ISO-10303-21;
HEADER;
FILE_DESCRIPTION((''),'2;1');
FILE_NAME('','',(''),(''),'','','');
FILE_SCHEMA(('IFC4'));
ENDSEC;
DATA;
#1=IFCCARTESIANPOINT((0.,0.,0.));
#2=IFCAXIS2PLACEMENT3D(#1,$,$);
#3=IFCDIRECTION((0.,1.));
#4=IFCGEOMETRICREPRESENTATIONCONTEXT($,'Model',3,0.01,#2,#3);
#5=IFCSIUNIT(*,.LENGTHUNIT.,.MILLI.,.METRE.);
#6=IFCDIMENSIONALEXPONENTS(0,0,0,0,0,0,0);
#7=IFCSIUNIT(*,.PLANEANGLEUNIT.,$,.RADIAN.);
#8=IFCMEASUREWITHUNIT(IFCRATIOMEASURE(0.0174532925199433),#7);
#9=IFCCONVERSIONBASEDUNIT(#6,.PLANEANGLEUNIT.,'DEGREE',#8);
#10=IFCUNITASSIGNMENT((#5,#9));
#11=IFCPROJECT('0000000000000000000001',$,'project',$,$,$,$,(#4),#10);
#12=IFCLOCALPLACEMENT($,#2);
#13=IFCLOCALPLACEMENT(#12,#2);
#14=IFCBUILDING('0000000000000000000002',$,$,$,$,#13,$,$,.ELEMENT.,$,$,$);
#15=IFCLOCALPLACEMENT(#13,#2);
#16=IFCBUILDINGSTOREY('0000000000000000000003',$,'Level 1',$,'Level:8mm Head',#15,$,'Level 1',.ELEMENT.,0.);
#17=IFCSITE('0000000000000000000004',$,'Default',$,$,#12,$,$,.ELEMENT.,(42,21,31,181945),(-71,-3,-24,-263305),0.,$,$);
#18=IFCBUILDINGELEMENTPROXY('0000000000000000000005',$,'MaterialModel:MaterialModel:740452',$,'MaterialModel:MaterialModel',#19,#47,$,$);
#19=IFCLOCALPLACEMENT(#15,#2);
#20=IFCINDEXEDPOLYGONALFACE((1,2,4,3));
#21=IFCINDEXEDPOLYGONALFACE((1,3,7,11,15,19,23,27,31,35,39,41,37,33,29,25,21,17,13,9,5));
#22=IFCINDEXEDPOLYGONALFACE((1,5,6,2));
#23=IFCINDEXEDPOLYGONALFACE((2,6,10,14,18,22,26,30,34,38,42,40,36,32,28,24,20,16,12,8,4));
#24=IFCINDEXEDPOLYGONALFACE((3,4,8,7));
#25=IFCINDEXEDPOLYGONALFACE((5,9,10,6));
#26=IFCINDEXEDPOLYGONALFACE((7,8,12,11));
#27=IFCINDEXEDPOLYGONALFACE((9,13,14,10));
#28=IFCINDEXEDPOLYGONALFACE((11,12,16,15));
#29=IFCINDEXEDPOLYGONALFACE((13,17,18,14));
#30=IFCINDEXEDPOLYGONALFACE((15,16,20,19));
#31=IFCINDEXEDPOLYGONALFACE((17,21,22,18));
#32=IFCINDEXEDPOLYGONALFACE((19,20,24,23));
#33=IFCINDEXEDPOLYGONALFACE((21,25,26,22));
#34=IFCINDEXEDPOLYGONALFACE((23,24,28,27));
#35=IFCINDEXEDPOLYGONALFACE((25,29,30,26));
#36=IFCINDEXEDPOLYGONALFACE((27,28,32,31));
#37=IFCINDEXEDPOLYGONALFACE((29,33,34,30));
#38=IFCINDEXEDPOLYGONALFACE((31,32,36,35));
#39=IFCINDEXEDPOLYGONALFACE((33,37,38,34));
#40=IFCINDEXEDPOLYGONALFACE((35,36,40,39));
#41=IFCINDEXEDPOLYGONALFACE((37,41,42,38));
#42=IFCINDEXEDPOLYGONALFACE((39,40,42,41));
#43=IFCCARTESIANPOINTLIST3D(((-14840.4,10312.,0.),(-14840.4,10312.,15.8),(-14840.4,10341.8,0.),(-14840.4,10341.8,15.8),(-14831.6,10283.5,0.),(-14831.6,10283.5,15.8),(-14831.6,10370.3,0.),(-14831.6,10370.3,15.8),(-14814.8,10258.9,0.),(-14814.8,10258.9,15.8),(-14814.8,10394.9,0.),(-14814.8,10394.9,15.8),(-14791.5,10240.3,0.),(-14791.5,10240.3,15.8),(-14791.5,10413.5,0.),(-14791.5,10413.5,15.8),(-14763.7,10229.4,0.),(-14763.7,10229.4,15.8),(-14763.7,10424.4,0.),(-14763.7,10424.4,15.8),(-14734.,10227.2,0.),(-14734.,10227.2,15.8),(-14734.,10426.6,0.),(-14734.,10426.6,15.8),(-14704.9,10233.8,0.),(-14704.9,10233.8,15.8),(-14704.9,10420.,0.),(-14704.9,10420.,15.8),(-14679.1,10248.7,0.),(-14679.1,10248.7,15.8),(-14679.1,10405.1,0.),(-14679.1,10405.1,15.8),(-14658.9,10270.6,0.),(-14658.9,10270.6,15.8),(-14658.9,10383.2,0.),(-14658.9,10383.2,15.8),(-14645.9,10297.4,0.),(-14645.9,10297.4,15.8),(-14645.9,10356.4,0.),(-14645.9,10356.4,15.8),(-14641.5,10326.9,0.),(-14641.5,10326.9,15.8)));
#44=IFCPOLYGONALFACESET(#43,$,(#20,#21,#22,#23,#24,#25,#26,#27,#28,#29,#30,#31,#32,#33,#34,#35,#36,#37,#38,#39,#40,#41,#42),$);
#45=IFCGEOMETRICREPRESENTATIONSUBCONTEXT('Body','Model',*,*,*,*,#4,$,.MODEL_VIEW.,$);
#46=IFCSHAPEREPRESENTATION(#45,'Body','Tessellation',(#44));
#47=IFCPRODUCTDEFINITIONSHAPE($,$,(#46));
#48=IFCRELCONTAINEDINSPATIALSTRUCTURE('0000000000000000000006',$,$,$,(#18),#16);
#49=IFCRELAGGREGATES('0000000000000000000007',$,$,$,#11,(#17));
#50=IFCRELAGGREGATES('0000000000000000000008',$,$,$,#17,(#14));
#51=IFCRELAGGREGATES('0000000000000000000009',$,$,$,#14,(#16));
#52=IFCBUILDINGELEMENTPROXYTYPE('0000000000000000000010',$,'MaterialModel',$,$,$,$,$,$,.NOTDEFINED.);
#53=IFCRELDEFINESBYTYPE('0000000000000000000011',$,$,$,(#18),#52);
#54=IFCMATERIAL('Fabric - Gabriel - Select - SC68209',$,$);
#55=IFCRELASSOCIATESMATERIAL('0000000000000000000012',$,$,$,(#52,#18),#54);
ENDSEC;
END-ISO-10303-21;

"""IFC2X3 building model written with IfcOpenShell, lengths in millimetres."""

from ifc_helpers import new_model, entity, si_unit, converted_unit, direction, frame, frame_2d, origin, place, context, subcontext, project, spatial, circle, extrude, source, transform, mapped, material, type_object, type_shapes, element, save


model = new_model("IFC2X3")

# Units and contexts
model_context = context("Model", 3, precision=0.01, world=origin(), true_north=direction((0.0, 1.0)))
body_context = subcontext(model_context, "Body", "Model", "MODEL_VIEW")
ifc_project = project(units=[si_unit("LENGTHUNIT", "METRE", prefix="MILLI"), converted_unit("PLANEANGLEUNIT", "DEGREE", entity("IfcRatioMeasure", 0.0174532925199433), si_unit("PLANEANGLEUNIT", "RADIAN"), dimensions=[0, 0, 0, 0, 0, 0, 0])], contexts=[model_context])

# Site, building, storey
site_placement = place(None, origin())
site = spatial("IfcSite", under=ifc_project, at=site_placement, Name="Default", CompositionType="ELEMENT", RefLatitude=(42, 21, 31, 181945), RefLongitude=(-71, -3, -24, -263305), RefElevation=0.0)
building_placement = place(site_placement, origin())
building = spatial("IfcBuilding", under=site, at=building_placement, CompositionType="ELEMENT")
storey_placement = place(building_placement, origin())
storey = spatial("IfcBuildingStorey", under=building, at=storey_placement, Name="Level 1", ObjectType="Level:8mm Head", LongName="Level 1", CompositionType="ELEMENT", Elevation=0.0)

# Building element proxy
ifc_material_1 = material(Name="Fabric - Gabriel - Select - SC68209")
building_element_proxy_type_1 = type_object("IfcBuildingElementProxyType", Name="MaterialModel", PredefinedType="NOTDEFINED", material=ifc_material_1)
shared_shape_1 = source(origin(), body_context, "Body", "SweptSolid", [
    extrude(circle(Radius=100.0, at=frame_2d((0.0, 0.0), x_axis=(1.0, 0.0))), origin(), (0.0, 0.0, 1.0), 15.8),
])
type_shapes(building_element_proxy_type_1, [shared_shape_1])
proxy_1_placement = place(storey_placement, frame((-14741.5, 10326.9, 0.0)))
element("IfcBuildingElementProxy", 1, at=proxy_1_placement, inside=storey, type_object=building_element_proxy_type_1, material=ifc_material_1, Name="MaterialModel:MaterialModel:740452", ObjectType="MaterialModel:MaterialModel", context=body_context, shape_type="MappedRepresentation", body=[
    mapped(shared_shape_1, transform((0.0, 0.0, 0.0), scale=1.0)),
])

save(model, "model.ifc")
